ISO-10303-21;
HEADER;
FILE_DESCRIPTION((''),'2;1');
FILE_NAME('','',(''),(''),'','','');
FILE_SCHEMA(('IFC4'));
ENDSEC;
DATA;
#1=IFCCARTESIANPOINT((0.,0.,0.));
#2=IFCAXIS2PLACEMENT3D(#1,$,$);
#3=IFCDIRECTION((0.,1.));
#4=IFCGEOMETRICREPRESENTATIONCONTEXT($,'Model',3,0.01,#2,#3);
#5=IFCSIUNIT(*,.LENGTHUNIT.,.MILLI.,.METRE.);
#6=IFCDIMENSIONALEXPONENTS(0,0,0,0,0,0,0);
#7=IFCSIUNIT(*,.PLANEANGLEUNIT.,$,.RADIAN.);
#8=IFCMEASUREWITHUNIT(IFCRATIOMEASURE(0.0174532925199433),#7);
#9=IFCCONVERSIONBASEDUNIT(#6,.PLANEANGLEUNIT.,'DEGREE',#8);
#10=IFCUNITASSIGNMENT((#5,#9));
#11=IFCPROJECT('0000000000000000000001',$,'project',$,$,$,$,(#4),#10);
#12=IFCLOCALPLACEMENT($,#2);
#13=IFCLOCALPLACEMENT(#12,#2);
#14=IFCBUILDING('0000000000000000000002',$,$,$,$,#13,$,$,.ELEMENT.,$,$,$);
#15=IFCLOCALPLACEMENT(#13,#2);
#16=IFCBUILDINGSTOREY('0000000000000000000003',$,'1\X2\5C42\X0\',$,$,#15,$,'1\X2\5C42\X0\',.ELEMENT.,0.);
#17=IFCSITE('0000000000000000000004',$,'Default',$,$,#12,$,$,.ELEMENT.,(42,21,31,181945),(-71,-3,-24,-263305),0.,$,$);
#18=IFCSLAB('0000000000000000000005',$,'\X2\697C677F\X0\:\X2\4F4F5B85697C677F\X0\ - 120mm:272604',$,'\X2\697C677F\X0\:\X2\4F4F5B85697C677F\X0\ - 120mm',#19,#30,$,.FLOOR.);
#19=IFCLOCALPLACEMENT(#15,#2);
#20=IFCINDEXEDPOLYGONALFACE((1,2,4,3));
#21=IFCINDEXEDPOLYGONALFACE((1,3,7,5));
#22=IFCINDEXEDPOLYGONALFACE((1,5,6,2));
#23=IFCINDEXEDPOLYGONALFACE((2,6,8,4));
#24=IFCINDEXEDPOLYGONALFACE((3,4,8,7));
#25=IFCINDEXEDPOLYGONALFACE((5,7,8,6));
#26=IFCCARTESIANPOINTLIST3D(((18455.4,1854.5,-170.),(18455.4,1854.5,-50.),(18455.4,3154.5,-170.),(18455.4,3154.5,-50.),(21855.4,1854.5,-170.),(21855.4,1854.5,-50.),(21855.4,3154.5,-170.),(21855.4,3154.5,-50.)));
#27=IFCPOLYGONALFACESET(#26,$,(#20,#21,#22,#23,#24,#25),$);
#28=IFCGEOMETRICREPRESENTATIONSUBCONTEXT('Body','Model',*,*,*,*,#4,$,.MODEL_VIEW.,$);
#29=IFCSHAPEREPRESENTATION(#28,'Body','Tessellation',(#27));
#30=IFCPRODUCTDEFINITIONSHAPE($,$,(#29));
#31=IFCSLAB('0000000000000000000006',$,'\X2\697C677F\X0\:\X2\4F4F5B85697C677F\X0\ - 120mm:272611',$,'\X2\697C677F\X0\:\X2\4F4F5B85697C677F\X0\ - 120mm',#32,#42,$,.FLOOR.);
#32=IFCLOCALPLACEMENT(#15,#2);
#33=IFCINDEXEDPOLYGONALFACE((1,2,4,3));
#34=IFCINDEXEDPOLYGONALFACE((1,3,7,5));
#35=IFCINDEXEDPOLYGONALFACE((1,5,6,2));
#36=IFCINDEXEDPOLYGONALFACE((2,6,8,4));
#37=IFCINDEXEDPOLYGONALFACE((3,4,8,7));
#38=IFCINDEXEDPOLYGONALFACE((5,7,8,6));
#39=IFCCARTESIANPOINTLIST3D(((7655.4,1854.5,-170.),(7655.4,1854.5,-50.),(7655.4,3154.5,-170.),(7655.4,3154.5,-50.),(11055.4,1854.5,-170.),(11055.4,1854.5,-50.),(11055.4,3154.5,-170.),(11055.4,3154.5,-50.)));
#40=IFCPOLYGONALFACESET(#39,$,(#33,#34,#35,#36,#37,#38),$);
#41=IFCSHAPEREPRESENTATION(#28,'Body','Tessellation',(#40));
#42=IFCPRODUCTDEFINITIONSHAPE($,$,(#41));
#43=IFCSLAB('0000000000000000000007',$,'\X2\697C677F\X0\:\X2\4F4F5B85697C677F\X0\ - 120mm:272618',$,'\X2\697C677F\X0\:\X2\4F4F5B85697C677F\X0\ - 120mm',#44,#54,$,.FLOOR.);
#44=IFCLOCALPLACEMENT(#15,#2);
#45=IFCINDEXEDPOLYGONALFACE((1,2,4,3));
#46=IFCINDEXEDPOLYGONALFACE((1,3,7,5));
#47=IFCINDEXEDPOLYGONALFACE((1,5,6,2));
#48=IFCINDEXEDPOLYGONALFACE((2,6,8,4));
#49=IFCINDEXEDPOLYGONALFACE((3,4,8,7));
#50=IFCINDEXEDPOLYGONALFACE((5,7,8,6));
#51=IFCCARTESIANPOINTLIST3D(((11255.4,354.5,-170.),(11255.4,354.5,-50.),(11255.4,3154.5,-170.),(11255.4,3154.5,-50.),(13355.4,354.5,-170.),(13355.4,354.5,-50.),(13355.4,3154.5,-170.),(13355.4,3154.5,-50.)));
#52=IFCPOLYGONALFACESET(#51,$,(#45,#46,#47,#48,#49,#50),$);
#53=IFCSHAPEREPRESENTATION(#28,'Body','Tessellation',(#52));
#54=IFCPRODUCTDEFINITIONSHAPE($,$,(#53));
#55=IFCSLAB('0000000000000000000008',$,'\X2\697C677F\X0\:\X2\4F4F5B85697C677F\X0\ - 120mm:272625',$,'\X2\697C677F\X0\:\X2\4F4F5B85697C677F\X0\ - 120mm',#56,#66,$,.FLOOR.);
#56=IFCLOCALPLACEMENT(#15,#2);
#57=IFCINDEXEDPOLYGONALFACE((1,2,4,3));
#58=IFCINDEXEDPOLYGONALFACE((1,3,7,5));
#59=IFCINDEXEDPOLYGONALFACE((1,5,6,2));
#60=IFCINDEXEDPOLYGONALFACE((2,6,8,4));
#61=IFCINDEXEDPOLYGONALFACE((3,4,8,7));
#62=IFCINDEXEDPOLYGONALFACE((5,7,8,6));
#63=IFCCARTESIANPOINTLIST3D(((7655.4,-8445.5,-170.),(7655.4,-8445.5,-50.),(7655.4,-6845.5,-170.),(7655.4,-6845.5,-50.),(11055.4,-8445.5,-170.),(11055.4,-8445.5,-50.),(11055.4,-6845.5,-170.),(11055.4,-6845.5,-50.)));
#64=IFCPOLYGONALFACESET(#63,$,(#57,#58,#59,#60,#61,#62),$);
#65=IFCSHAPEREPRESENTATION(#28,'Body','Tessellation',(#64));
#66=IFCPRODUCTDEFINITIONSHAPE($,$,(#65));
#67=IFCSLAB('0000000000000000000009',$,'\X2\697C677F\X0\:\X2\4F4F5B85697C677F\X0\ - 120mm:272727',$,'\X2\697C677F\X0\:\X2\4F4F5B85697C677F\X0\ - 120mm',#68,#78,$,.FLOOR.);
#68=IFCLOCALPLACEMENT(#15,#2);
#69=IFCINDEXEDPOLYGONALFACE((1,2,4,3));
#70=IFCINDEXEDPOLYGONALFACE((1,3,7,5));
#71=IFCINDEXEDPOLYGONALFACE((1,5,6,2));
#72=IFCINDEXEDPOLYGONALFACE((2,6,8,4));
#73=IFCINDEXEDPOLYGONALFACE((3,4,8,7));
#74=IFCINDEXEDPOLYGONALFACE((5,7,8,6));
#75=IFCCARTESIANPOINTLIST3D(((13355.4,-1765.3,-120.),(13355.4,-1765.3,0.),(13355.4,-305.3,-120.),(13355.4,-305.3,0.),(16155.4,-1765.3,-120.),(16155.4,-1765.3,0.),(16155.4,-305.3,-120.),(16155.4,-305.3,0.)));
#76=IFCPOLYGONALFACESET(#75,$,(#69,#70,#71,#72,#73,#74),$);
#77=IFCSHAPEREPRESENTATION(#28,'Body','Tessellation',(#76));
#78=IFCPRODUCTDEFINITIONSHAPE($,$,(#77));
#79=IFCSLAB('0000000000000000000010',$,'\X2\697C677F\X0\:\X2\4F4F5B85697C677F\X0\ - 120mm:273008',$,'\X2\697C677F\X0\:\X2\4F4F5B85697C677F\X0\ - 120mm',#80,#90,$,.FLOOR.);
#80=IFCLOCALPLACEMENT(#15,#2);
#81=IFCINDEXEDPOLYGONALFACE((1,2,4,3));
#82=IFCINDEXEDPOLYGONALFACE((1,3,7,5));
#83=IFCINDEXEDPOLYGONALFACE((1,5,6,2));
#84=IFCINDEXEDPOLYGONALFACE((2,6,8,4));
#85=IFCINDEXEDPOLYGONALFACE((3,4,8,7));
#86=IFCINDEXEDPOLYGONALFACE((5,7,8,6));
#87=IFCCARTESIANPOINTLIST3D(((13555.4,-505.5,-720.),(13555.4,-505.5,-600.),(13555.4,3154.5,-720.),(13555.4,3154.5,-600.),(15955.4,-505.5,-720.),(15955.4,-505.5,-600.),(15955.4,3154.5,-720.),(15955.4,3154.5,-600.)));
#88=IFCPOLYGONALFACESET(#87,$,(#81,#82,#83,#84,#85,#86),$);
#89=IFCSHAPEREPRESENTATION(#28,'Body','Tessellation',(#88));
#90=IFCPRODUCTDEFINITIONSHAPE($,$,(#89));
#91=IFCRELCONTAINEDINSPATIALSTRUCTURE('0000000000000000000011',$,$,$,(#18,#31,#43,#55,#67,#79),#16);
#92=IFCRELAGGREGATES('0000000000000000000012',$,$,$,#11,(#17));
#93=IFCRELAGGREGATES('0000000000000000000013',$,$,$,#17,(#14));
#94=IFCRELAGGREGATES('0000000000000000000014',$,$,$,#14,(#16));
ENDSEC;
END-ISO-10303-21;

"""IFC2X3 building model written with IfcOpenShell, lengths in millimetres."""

from ifc_helpers import new_model, entity, si_unit, converted_unit, direction, frame, frame_2d, origin, origin_2d_with_axis, place, context, subcontext, project, spatial, rectangle, extrude, element, save


model = new_model("IFC2X3")

# Units and contexts
model_context = context("Model", 3, precision=0.01, world=origin(), true_north=direction((0.0, 1.0)))
body_context = subcontext(model_context, "Body", "Model", "MODEL_VIEW")
ifc_project = project(units=[si_unit("LENGTHUNIT", "METRE", prefix="MILLI"), converted_unit("PLANEANGLEUNIT", "DEGREE", entity("IfcRatioMeasure", 0.0174532925199433), si_unit("PLANEANGLEUNIT", "RADIAN"), dimensions=[0, 0, 0, 0, 0, 0, 0])], contexts=[model_context])

# Site, building, storey
site_placement = place(None, origin())
site = spatial("IfcSite", under=ifc_project, at=site_placement, Name="Default", CompositionType="ELEMENT", RefLatitude=(42, 21, 31, 181945), RefLongitude=(-71, -3, -24, -263305), RefElevation=0.0)
building_placement = place(site_placement, origin())
building = spatial("IfcBuilding", under=site, at=building_placement, CompositionType="ELEMENT")
storey_placement = place(building_placement, origin())
storey = spatial("IfcBuildingStorey", under=building, at=storey_placement, Name="1层", LongName="1层", CompositionType="ELEMENT", Elevation=0.0)

# Slabs
slab_1_placement = place(storey_placement, origin())
element("IfcSlab", 1, at=slab_1_placement, inside=storey, Name="楼板:住宅楼板 - 120mm:272604", ObjectType="楼板:住宅楼板 - 120mm", PredefinedType="FLOOR", context=body_context, shape_type="SweptSolid", body=[
    extrude(rectangle(XDim=1300.0, YDim=3400.0, at=frame_2d((0.0, 0.0), x_axis=(1.0, 0.0))), frame((20155.4, 2504.5, -50.0), z_axis=(0.0, 0.0, -1.0), x_axis=(0.0, 1.0, 0.0)), (0.0, 0.0, 1.0), 120.0),
])
slab_2_placement = place(storey_placement, origin())
element("IfcSlab", 2, at=slab_2_placement, inside=storey, Name="楼板:住宅楼板 - 120mm:272611", ObjectType="楼板:住宅楼板 - 120mm", PredefinedType="FLOOR", context=body_context, shape_type="SweptSolid", body=[
    extrude(rectangle(XDim=1300.0, YDim=3400.0, at=frame_2d((0.0, 0.0), x_axis=(1.0, 0.0))), frame((9355.4, 2504.5, -50.0), z_axis=(0.0, 0.0, -1.0), x_axis=(0.0, 1.0, 0.0)), (0.0, 0.0, 1.0), 120.0),
])
slab_3_placement = place(storey_placement, origin())
element("IfcSlab", 3, at=slab_3_placement, inside=storey, Name="楼板:住宅楼板 - 120mm:272618", ObjectType="楼板:住宅楼板 - 120mm", PredefinedType="FLOOR", context=body_context, shape_type="SweptSolid", body=[
    extrude(rectangle(XDim=2800.0, YDim=2100.0, at=origin_2d_with_axis()), frame((12305.4, 1754.5, -50.0), z_axis=(0.0, 0.0, -1.0), x_axis=(0.0, 1.0, 0.0)), (0.0, 0.0, 1.0), 120.0),
])
slab_4_placement = place(storey_placement, origin())
element("IfcSlab", 4, at=slab_4_placement, inside=storey, Name="楼板:住宅楼板 - 120mm:272625", ObjectType="楼板:住宅楼板 - 120mm", PredefinedType="FLOOR", context=body_context, shape_type="SweptSolid", body=[
    extrude(rectangle(XDim=1600.0, YDim=3400.0, at=origin_2d_with_axis()), frame((9355.4, -7645.5, -50.0), z_axis=(0.0, 0.0, -1.0), x_axis=(0.0, 1.0, 0.0)), (0.0, 0.0, 1.0), 120.0),
])
slab_5_placement = place(storey_placement, origin())
element("IfcSlab", 5, at=slab_5_placement, inside=storey, Name="楼板:住宅楼板 - 120mm:272727", ObjectType="楼板:住宅楼板 - 120mm", PredefinedType="FLOOR", context=body_context, shape_type="SweptSolid", body=[
    extrude(rectangle(XDim=1460.0, YDim=2800.0, at=frame_2d((0.0, 0.0), x_axis=(1.0, 0.0))), frame((14755.4, -1035.3, 0.0), z_axis=(0.0, 0.0, -1.0), x_axis=(0.0, 1.0, 0.0)), (0.0, 0.0, 1.0), 120.0),
])
slab_6_placement = place(storey_placement, origin())
element("IfcSlab", 6, at=slab_6_placement, inside=storey, Name="楼板:住宅楼板 - 120mm:273008", ObjectType="楼板:住宅楼板 - 120mm", PredefinedType="FLOOR", context=body_context, shape_type="SweptSolid", body=[
    extrude(rectangle(XDim=3660.0, YDim=2400.0, at=origin_2d_with_axis()), frame((14755.4, 1324.5, -600.0), z_axis=(0.0, 0.0, -1.0), x_axis=(0.0, 1.0, 0.0)), (0.0, 0.0, 1.0), 120.0),
])

save(model, "model.ifc")
